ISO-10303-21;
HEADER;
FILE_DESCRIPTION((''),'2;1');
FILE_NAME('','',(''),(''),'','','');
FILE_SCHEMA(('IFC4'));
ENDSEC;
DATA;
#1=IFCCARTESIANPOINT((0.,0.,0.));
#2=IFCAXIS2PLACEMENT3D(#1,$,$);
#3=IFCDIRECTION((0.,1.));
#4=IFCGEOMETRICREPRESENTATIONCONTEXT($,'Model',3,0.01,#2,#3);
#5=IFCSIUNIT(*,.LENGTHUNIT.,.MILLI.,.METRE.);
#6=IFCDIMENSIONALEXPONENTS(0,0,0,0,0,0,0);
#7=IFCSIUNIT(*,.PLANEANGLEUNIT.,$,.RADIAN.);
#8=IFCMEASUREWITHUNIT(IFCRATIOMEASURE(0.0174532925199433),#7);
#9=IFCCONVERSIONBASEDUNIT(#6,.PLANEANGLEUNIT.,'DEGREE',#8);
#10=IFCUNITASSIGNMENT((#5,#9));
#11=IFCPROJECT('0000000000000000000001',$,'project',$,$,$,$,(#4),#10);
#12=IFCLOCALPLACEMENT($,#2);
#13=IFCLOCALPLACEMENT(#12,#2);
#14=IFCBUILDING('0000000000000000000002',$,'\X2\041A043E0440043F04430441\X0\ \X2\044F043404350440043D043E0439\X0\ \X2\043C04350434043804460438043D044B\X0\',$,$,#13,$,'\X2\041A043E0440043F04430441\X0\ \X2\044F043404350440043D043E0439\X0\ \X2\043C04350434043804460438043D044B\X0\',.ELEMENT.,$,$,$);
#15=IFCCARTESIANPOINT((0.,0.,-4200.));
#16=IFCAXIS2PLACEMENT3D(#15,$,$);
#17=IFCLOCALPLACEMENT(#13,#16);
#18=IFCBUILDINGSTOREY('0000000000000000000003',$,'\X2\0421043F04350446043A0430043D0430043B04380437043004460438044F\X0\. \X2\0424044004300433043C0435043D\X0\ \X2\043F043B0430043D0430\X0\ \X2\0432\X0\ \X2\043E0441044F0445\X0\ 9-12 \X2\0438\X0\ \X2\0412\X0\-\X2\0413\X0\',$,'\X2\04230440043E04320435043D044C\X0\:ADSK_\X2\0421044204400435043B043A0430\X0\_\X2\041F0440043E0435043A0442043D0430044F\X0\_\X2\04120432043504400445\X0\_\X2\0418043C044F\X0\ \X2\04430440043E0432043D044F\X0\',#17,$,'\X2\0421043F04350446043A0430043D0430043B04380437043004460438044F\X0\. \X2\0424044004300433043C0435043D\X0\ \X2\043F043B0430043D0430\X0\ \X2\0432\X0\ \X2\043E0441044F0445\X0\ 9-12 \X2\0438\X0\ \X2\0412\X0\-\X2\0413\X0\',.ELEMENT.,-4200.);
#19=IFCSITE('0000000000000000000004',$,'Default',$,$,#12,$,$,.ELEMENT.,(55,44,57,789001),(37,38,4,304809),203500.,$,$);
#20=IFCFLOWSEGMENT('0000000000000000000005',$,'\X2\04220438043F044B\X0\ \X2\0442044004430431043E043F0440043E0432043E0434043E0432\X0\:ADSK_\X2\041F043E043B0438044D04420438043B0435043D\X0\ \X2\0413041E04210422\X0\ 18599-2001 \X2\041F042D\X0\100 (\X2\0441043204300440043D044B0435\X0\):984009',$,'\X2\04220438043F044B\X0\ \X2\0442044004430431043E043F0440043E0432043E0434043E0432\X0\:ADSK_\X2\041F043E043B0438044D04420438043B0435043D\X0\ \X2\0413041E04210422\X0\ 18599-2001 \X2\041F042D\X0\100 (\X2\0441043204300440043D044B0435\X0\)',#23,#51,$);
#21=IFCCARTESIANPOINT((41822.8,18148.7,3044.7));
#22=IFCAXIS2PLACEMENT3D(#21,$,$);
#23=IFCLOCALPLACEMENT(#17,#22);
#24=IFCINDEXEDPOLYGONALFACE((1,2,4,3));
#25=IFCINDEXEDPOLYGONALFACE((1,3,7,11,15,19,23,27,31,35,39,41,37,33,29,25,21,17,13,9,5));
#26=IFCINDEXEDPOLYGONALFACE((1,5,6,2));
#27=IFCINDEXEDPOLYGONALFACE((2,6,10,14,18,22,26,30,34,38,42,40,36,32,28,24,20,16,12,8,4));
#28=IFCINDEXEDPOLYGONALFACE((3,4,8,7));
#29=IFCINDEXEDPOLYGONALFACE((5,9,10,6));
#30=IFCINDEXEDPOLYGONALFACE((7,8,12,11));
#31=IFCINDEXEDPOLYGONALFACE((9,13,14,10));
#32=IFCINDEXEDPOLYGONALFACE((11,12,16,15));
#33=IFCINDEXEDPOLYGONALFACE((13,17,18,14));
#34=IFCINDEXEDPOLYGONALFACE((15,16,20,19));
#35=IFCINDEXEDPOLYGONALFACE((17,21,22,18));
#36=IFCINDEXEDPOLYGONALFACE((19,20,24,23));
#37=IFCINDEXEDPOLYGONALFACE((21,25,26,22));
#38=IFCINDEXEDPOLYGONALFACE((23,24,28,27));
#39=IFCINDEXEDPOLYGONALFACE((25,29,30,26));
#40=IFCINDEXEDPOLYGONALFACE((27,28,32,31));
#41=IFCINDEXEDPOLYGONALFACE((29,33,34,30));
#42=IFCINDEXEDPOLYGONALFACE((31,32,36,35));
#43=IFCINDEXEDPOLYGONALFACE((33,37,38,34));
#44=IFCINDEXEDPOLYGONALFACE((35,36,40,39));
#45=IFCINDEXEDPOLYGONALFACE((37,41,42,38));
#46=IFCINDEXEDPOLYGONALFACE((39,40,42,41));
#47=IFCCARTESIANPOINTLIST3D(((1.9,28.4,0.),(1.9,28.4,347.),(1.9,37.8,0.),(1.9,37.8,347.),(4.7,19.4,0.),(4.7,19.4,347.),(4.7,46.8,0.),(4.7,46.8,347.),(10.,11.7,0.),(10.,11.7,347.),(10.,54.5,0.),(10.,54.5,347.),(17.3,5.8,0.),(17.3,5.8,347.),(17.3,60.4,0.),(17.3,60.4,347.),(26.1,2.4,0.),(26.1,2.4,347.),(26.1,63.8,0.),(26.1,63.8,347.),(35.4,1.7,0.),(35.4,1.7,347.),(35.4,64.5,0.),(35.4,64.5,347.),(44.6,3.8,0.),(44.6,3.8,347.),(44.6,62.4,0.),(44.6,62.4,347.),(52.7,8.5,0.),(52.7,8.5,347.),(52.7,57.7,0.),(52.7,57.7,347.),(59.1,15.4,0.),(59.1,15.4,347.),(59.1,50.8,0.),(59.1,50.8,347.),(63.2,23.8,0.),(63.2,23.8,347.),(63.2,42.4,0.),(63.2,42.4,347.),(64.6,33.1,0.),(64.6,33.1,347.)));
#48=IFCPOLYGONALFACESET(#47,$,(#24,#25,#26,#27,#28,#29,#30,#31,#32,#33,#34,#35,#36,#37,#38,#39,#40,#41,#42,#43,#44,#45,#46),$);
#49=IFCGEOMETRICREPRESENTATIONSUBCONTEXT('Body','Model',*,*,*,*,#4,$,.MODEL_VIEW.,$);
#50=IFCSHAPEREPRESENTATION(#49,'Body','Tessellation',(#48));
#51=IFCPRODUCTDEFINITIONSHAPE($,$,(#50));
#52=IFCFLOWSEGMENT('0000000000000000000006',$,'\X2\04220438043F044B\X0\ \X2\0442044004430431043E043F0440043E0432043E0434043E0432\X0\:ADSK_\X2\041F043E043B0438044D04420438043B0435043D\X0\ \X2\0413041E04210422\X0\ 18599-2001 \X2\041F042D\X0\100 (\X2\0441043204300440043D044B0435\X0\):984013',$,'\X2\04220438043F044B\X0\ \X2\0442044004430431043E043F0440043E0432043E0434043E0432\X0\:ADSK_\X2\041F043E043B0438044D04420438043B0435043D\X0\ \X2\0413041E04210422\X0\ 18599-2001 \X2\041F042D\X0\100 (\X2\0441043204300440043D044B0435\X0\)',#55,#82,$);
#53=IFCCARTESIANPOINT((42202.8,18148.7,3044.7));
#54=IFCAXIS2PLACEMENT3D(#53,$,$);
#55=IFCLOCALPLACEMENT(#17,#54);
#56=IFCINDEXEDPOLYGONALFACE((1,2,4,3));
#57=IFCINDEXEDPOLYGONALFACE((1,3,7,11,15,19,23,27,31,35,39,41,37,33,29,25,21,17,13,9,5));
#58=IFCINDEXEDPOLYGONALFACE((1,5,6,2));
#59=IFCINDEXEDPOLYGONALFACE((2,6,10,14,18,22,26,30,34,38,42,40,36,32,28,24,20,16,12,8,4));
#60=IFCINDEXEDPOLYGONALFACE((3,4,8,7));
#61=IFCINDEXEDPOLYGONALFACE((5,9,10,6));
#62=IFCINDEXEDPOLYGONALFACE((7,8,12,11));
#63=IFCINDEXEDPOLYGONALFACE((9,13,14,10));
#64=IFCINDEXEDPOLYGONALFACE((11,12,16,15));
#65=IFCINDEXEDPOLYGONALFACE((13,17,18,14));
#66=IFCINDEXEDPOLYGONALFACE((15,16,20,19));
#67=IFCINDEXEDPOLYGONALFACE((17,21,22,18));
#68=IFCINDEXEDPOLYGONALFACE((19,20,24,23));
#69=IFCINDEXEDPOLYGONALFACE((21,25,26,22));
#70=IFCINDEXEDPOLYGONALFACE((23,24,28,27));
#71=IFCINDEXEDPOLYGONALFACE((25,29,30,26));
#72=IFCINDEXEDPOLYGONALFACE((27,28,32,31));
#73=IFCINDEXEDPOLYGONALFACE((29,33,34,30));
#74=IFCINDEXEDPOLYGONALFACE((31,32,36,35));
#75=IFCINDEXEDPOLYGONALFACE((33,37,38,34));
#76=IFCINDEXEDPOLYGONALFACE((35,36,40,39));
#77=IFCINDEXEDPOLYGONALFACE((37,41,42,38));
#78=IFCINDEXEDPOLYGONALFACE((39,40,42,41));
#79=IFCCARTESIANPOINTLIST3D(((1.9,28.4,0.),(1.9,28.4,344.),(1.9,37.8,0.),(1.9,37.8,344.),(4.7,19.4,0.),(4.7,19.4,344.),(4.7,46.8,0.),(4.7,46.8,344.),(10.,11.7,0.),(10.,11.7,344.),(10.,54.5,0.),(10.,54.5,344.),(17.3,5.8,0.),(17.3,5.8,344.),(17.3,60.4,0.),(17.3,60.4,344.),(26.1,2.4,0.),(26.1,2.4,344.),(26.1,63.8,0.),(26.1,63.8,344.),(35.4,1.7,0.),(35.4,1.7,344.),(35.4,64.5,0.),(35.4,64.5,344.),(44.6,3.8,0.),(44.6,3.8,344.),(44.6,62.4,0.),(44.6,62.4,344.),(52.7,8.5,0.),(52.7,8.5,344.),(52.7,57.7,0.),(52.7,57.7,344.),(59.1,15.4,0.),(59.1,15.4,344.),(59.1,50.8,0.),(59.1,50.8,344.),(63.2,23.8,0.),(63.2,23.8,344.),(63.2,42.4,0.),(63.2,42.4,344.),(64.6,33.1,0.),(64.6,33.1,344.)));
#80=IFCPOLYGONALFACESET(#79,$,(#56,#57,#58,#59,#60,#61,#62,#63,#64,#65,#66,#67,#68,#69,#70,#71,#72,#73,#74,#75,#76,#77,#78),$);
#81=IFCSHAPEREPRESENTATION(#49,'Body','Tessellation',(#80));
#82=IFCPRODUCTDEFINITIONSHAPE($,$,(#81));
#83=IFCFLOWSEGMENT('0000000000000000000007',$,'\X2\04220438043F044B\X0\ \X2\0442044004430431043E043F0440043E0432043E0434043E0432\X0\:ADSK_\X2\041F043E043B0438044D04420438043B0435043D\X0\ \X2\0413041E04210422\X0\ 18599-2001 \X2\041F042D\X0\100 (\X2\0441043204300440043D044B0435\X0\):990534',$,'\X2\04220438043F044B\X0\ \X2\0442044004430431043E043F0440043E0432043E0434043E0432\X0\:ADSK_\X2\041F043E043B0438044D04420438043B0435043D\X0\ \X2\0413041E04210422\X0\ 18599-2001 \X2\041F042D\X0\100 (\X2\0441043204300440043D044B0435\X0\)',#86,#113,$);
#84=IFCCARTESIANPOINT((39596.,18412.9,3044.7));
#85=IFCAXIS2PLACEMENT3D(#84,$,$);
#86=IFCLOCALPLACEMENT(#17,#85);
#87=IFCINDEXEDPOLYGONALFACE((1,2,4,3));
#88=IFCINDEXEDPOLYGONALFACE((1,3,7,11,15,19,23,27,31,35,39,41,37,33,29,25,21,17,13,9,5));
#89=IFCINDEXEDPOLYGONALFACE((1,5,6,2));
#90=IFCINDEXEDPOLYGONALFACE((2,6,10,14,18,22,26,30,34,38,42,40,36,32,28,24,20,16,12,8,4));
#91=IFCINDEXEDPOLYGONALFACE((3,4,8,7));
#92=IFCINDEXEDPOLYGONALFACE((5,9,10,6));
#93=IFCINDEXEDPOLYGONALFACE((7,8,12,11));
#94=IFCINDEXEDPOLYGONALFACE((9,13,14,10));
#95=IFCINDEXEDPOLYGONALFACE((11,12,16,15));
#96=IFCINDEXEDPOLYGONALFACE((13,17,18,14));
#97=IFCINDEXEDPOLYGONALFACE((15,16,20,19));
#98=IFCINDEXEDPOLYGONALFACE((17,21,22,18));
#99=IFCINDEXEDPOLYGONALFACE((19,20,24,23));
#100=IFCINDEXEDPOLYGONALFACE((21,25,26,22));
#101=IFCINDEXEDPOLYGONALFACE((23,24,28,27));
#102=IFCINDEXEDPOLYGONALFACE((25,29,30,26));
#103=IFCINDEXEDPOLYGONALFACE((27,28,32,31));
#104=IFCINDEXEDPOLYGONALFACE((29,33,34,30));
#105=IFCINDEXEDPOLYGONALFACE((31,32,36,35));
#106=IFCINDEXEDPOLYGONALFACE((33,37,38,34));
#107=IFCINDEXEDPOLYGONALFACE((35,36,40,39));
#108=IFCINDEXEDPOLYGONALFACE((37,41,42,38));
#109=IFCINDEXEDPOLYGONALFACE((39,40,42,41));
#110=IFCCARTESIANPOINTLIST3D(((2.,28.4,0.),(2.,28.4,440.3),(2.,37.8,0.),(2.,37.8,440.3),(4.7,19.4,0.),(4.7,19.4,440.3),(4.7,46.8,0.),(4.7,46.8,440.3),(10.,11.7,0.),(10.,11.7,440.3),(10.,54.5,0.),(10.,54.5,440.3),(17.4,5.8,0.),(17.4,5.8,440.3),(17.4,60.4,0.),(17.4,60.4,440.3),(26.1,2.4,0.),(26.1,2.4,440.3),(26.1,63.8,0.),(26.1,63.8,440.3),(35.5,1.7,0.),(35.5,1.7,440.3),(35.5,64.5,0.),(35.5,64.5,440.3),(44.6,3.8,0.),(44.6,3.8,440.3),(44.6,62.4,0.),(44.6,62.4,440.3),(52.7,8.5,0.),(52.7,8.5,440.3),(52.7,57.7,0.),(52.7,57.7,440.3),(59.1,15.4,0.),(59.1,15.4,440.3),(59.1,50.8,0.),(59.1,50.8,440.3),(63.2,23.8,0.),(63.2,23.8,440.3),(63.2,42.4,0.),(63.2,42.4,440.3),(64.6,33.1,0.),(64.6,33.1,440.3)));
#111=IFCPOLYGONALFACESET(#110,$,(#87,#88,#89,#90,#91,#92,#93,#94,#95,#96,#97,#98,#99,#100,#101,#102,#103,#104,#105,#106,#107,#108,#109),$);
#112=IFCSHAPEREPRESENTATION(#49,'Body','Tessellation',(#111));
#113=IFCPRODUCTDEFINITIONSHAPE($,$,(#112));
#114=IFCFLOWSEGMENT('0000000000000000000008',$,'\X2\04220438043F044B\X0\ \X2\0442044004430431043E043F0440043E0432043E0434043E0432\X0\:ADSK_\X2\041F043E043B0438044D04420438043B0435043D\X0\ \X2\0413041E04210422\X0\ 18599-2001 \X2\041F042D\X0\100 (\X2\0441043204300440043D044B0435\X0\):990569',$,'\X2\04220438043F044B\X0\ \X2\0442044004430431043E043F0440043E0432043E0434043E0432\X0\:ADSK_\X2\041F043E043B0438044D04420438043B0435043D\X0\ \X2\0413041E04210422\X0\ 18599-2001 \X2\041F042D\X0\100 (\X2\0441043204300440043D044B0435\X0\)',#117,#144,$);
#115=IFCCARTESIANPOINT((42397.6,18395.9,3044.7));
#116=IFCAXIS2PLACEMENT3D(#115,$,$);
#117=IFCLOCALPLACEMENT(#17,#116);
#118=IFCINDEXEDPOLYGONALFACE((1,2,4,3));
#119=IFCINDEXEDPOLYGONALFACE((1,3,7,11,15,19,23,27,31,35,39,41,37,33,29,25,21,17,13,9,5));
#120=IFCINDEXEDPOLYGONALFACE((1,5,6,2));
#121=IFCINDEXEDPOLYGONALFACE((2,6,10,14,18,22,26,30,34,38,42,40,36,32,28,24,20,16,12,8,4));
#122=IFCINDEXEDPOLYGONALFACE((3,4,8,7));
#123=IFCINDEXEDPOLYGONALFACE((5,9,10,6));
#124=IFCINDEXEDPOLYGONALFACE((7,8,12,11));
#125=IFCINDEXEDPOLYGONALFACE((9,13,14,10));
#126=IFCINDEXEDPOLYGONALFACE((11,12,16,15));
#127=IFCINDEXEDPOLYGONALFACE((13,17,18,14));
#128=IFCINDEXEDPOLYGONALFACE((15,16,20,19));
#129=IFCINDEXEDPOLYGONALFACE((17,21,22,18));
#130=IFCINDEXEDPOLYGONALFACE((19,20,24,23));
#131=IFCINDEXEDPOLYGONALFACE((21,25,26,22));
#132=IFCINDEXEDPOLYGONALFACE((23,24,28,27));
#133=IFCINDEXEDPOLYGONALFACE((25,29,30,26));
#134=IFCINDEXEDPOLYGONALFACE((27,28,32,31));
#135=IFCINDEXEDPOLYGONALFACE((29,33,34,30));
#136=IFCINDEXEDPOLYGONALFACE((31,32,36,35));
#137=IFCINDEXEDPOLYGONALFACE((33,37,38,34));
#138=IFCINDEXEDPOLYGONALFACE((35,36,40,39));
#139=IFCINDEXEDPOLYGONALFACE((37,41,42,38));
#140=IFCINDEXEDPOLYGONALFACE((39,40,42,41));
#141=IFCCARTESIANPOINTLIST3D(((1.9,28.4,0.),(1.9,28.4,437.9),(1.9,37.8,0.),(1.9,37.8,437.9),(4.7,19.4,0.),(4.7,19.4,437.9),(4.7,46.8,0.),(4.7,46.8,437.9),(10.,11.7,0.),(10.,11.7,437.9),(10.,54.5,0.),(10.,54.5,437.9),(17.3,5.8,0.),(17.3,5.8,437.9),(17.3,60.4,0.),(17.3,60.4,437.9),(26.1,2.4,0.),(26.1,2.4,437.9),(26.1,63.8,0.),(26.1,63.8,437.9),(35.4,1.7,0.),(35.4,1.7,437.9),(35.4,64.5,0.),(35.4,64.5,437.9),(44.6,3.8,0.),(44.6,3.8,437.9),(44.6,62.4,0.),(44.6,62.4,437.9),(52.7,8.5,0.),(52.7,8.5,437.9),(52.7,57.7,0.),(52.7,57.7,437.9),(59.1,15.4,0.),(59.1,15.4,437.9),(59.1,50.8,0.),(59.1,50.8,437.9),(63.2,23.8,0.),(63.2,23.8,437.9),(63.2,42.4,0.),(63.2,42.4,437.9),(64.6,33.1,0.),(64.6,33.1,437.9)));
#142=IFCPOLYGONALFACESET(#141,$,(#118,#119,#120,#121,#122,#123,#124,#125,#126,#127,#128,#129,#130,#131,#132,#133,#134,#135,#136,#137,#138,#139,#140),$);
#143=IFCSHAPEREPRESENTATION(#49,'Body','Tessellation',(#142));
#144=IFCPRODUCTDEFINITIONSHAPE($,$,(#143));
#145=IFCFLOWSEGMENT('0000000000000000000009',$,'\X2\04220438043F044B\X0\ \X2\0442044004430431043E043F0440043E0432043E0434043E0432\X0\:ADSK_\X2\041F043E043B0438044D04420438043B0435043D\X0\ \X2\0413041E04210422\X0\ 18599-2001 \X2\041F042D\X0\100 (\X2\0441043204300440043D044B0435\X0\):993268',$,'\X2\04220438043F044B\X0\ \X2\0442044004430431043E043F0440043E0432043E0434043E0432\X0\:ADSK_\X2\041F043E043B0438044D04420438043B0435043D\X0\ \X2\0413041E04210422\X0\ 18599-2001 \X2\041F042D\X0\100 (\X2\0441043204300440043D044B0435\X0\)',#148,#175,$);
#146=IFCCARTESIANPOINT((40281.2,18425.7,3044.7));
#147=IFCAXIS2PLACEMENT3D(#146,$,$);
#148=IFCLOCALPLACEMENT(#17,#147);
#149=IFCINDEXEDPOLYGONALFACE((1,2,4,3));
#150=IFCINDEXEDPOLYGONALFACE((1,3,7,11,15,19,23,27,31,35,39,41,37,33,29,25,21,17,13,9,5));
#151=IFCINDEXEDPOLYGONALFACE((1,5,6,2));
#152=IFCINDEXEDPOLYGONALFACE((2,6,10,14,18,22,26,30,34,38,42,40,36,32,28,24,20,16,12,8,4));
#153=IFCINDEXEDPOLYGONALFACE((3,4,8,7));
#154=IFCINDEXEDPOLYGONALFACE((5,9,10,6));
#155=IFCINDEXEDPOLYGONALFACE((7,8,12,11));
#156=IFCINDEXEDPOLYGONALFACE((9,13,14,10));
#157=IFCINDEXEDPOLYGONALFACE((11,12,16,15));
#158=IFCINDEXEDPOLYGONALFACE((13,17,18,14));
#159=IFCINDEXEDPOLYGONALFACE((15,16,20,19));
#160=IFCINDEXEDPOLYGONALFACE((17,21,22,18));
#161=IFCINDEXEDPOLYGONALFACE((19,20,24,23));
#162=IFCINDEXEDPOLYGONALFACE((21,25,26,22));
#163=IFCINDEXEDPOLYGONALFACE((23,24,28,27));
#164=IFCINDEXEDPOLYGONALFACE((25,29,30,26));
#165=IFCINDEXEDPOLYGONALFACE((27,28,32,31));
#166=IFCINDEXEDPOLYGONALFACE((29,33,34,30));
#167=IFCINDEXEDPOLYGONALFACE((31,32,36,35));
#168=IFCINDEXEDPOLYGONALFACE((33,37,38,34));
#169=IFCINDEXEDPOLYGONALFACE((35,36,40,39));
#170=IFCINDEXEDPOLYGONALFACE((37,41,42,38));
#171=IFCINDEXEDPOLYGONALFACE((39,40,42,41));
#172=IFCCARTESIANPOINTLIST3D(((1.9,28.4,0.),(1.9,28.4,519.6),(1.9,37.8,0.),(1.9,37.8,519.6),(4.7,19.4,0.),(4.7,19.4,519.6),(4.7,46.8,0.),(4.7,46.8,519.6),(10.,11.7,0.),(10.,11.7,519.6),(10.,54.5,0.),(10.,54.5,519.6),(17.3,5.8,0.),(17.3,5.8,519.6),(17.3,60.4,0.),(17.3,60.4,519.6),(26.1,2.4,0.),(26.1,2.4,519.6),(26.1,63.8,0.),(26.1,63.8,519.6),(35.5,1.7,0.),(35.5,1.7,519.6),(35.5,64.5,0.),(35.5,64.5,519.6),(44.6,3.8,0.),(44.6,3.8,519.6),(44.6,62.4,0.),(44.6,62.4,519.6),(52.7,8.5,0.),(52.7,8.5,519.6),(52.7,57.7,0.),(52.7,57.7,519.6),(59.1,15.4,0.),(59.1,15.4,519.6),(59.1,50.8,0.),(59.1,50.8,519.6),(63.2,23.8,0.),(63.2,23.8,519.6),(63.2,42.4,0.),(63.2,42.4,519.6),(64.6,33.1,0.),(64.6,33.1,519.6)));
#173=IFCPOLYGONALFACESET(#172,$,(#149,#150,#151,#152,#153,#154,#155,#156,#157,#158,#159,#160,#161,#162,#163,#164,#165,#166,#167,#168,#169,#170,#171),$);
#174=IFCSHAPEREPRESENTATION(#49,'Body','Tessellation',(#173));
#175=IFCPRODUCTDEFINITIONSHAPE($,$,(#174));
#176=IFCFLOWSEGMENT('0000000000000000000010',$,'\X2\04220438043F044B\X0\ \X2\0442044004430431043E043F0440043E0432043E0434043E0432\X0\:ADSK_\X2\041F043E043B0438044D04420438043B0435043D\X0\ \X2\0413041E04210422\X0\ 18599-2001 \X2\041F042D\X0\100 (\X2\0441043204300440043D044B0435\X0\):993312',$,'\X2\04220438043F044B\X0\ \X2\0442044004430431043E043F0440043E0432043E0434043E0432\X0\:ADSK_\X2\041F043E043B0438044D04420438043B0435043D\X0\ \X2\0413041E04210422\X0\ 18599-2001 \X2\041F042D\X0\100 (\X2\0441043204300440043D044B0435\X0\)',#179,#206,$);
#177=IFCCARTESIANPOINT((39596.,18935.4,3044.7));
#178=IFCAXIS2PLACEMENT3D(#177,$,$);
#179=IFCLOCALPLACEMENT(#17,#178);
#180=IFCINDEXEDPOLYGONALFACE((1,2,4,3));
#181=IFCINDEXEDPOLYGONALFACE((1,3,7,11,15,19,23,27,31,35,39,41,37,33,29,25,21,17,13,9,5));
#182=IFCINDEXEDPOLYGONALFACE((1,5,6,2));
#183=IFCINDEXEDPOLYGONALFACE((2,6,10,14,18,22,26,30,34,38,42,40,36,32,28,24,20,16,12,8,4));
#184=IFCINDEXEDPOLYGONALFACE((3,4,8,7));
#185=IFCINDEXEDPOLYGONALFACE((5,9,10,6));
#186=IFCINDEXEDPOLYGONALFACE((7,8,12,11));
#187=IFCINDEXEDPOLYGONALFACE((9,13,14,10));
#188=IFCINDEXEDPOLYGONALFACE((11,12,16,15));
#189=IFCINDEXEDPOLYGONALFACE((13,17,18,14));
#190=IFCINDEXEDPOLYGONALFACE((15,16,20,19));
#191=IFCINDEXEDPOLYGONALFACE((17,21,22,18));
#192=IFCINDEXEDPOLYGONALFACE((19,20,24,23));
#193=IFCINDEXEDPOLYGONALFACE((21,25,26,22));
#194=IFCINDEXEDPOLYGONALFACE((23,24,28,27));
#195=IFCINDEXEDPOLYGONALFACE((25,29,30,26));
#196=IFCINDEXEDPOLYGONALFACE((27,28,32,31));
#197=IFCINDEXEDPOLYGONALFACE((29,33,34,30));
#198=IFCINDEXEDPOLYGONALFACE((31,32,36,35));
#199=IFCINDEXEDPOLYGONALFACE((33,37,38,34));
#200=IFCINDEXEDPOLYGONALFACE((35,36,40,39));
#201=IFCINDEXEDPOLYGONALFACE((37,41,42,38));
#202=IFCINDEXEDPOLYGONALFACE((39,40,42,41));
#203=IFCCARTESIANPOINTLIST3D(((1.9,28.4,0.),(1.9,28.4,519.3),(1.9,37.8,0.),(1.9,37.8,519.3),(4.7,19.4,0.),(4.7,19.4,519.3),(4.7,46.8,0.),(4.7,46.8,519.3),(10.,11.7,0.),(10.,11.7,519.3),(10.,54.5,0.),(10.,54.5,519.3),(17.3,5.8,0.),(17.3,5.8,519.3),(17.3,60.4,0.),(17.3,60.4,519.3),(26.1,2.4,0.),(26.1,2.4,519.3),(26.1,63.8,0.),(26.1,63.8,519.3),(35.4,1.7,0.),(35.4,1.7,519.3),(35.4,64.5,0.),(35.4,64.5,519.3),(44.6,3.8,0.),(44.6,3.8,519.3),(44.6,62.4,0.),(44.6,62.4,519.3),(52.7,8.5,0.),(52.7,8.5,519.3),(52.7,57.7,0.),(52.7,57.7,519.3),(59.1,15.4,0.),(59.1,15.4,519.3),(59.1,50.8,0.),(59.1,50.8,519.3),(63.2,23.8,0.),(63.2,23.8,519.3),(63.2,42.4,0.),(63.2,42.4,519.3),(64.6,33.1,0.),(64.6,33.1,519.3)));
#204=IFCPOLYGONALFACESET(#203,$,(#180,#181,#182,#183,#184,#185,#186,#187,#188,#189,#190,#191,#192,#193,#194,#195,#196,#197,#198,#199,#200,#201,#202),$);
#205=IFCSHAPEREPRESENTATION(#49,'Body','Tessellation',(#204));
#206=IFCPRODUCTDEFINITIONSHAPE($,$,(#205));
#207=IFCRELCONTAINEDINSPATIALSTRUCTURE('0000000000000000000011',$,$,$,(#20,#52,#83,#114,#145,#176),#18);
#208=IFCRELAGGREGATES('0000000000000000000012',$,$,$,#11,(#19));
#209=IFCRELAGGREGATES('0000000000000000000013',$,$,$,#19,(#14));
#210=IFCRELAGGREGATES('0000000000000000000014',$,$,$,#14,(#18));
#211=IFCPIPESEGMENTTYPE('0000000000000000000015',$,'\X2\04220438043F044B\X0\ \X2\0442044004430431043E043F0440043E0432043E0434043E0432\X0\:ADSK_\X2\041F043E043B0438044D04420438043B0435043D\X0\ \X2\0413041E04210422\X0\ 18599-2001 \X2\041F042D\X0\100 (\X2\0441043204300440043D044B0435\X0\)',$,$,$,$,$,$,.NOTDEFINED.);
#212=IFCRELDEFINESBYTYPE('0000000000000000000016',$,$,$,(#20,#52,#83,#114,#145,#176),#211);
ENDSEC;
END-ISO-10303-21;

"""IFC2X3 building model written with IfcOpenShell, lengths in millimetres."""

from ifc_helpers import new_model, entity, si_unit, converted_unit, direction, frame, frame_2d, origin, origin_2d_with_axis, place, context, subcontext, project, spatial, circle, extrude, type_object, element, save


model = new_model("IFC2X3")

# Units and contexts
model_context = context("Model", 3, precision=0.01, world=origin(), true_north=direction((0.0, 1.0)))
body_context = subcontext(model_context, "Body", "Model", "MODEL_VIEW")
ifc_project = project(units=[si_unit("LENGTHUNIT", "METRE", prefix="MILLI"), converted_unit("PLANEANGLEUNIT", "DEGREE", entity("IfcRatioMeasure", 0.0174532925199433), si_unit("PLANEANGLEUNIT", "RADIAN"), dimensions=[0, 0, 0, 0, 0, 0, 0])], contexts=[model_context])

# Site, building, storey
site_placement = place(None, frame((0.0, 0.0, 0.0)))
site = spatial("IfcSite", under=ifc_project, at=site_placement, Name="Default", CompositionType="ELEMENT", RefLatitude=(55, 44, 57, 789001), RefLongitude=(37, 38, 4, 304809), RefElevation=203500.0)
building_placement = place(site_placement, origin())
building = spatial("IfcBuilding", under=site, at=building_placement, Name="Корпус ядерной медицины", LongName="Корпус ядерной медицины", CompositionType="ELEMENT")
storey_placement = place(building_placement, frame((0.0, 0.0, -4200.0)))
storey = spatial("IfcBuildingStorey", under=building, at=storey_placement, Name="Спецканализация. Фрагмен плана в осях 9-12 и В-Г", ObjectType="Уровень:ADSK_Стрелка_Проектная_Вверх_Имя уровня", LongName="Спецканализация. Фрагмен плана в осях 9-12 и В-Г", CompositionType="ELEMENT", Elevation=-4200.0)

# Flow segments
pipe_segment_type = type_object("IfcPipeSegmentType", Name="Типы трубопроводов:ADSK_Полиэтилен ГОСТ 18599-2001 ПЭ100 (сварные)", PredefinedType="NOTDEFINED")
flow_segment_1_placement = place(storey_placement, frame((41822.8, 18148.7, 3044.7)))
element("IfcFlowSegment", 1, at=flow_segment_1_placement, inside=storey, type_object=pipe_segment_type, Name="Типы трубопроводов:ADSK_Полиэтилен ГОСТ 18599-2001 ПЭ100 (сварные):984009", ObjectType="Типы трубопроводов:ADSK_Полиэтилен ГОСТ 18599-2001 ПЭ100 (сварные)", context=body_context, shape_type="SweptSolid", body=[
    extrude(circle(Radius=31.5, at=origin_2d_with_axis()), frame((33.1, 33.1, 0.0)), (0.0, 0.0, 1.0), 347.0),
])
flow_segment_2_placement = place(storey_placement, frame((42202.8, 18148.7, 3044.7)))
element("IfcFlowSegment", 2, at=flow_segment_2_placement, inside=storey, type_object=pipe_segment_type, Name="Типы трубопроводов:ADSK_Полиэтилен ГОСТ 18599-2001 ПЭ100 (сварные):984013", ObjectType="Типы трубопроводов:ADSK_Полиэтилен ГОСТ 18599-2001 ПЭ100 (сварные)", context=body_context, shape_type="SweptSolid", body=[
    extrude(circle(Radius=31.5, at=frame_2d((0.0, 0.0), x_axis=(1.0, 0.0))), frame((33.1, 33.1, 0.0)), (0.0, 0.0, 1.0), 344.0),
])
flow_segment_3_placement = place(storey_placement, frame((39596.0, 18412.9, 3044.7)))
element("IfcFlowSegment", 3, at=flow_segment_3_placement, inside=storey, type_object=pipe_segment_type, Name="Типы трубопроводов:ADSK_Полиэтилен ГОСТ 18599-2001 ПЭ100 (сварные):990534", ObjectType="Типы трубопроводов:ADSK_Полиэтилен ГОСТ 18599-2001 ПЭ100 (сварные)", context=body_context, shape_type="SweptSolid", body=[
    extrude(circle(Radius=31.5, at=origin_2d_with_axis()), frame((33.1, 33.1, 0.0)), (0.0, 0.0, 1.0), 440.3),
])
flow_segment_4_placement = place(storey_placement, frame((42397.6, 18395.9, 3044.7)))
element("IfcFlowSegment", 4, at=flow_segment_4_placement, inside=storey, type_object=pipe_segment_type, Name="Типы трубопроводов:ADSK_Полиэтилен ГОСТ 18599-2001 ПЭ100 (сварные):990569", ObjectType="Типы трубопроводов:ADSK_Полиэтилен ГОСТ 18599-2001 ПЭ100 (сварные)", context=body_context, shape_type="SweptSolid", body=[
    extrude(circle(Radius=31.5, at=origin_2d_with_axis()), frame((33.1, 33.1, 0.0)), (0.0, 0.0, 1.0), 437.9),
])
flow_segment_5_placement = place(storey_placement, frame((40281.2, 18425.7, 3044.7)))
element("IfcFlowSegment", 5, at=flow_segment_5_placement, inside=storey, type_object=pipe_segment_type, Name="Типы трубопроводов:ADSK_Полиэтилен ГОСТ 18599-2001 ПЭ100 (сварные):993268", ObjectType="Типы трубопроводов:ADSK_Полиэтилен ГОСТ 18599-2001 ПЭ100 (сварные)", context=body_context, shape_type="SweptSolid", body=[
    extrude(circle(Radius=31.5, at=origin_2d_with_axis()), frame((33.1, 33.1, 0.0)), (0.0, 0.0, 1.0), 519.6),
])
flow_segment_6_placement = place(storey_placement, frame((39596.0, 18935.4, 3044.7)))
element("IfcFlowSegment", 6, at=flow_segment_6_placement, inside=storey, type_object=pipe_segment_type, Name="Типы трубопроводов:ADSK_Полиэтилен ГОСТ 18599-2001 ПЭ100 (сварные):993312", ObjectType="Типы трубопроводов:ADSK_Полиэтилен ГОСТ 18599-2001 ПЭ100 (сварные)", context=body_context, shape_type="SweptSolid", body=[
    extrude(circle(Radius=31.5, at=origin_2d_with_axis()), frame((33.1, 33.1, 0.0)), (0.0, 0.0, 1.0), 519.3),
])

save(model, "model.ifc")
